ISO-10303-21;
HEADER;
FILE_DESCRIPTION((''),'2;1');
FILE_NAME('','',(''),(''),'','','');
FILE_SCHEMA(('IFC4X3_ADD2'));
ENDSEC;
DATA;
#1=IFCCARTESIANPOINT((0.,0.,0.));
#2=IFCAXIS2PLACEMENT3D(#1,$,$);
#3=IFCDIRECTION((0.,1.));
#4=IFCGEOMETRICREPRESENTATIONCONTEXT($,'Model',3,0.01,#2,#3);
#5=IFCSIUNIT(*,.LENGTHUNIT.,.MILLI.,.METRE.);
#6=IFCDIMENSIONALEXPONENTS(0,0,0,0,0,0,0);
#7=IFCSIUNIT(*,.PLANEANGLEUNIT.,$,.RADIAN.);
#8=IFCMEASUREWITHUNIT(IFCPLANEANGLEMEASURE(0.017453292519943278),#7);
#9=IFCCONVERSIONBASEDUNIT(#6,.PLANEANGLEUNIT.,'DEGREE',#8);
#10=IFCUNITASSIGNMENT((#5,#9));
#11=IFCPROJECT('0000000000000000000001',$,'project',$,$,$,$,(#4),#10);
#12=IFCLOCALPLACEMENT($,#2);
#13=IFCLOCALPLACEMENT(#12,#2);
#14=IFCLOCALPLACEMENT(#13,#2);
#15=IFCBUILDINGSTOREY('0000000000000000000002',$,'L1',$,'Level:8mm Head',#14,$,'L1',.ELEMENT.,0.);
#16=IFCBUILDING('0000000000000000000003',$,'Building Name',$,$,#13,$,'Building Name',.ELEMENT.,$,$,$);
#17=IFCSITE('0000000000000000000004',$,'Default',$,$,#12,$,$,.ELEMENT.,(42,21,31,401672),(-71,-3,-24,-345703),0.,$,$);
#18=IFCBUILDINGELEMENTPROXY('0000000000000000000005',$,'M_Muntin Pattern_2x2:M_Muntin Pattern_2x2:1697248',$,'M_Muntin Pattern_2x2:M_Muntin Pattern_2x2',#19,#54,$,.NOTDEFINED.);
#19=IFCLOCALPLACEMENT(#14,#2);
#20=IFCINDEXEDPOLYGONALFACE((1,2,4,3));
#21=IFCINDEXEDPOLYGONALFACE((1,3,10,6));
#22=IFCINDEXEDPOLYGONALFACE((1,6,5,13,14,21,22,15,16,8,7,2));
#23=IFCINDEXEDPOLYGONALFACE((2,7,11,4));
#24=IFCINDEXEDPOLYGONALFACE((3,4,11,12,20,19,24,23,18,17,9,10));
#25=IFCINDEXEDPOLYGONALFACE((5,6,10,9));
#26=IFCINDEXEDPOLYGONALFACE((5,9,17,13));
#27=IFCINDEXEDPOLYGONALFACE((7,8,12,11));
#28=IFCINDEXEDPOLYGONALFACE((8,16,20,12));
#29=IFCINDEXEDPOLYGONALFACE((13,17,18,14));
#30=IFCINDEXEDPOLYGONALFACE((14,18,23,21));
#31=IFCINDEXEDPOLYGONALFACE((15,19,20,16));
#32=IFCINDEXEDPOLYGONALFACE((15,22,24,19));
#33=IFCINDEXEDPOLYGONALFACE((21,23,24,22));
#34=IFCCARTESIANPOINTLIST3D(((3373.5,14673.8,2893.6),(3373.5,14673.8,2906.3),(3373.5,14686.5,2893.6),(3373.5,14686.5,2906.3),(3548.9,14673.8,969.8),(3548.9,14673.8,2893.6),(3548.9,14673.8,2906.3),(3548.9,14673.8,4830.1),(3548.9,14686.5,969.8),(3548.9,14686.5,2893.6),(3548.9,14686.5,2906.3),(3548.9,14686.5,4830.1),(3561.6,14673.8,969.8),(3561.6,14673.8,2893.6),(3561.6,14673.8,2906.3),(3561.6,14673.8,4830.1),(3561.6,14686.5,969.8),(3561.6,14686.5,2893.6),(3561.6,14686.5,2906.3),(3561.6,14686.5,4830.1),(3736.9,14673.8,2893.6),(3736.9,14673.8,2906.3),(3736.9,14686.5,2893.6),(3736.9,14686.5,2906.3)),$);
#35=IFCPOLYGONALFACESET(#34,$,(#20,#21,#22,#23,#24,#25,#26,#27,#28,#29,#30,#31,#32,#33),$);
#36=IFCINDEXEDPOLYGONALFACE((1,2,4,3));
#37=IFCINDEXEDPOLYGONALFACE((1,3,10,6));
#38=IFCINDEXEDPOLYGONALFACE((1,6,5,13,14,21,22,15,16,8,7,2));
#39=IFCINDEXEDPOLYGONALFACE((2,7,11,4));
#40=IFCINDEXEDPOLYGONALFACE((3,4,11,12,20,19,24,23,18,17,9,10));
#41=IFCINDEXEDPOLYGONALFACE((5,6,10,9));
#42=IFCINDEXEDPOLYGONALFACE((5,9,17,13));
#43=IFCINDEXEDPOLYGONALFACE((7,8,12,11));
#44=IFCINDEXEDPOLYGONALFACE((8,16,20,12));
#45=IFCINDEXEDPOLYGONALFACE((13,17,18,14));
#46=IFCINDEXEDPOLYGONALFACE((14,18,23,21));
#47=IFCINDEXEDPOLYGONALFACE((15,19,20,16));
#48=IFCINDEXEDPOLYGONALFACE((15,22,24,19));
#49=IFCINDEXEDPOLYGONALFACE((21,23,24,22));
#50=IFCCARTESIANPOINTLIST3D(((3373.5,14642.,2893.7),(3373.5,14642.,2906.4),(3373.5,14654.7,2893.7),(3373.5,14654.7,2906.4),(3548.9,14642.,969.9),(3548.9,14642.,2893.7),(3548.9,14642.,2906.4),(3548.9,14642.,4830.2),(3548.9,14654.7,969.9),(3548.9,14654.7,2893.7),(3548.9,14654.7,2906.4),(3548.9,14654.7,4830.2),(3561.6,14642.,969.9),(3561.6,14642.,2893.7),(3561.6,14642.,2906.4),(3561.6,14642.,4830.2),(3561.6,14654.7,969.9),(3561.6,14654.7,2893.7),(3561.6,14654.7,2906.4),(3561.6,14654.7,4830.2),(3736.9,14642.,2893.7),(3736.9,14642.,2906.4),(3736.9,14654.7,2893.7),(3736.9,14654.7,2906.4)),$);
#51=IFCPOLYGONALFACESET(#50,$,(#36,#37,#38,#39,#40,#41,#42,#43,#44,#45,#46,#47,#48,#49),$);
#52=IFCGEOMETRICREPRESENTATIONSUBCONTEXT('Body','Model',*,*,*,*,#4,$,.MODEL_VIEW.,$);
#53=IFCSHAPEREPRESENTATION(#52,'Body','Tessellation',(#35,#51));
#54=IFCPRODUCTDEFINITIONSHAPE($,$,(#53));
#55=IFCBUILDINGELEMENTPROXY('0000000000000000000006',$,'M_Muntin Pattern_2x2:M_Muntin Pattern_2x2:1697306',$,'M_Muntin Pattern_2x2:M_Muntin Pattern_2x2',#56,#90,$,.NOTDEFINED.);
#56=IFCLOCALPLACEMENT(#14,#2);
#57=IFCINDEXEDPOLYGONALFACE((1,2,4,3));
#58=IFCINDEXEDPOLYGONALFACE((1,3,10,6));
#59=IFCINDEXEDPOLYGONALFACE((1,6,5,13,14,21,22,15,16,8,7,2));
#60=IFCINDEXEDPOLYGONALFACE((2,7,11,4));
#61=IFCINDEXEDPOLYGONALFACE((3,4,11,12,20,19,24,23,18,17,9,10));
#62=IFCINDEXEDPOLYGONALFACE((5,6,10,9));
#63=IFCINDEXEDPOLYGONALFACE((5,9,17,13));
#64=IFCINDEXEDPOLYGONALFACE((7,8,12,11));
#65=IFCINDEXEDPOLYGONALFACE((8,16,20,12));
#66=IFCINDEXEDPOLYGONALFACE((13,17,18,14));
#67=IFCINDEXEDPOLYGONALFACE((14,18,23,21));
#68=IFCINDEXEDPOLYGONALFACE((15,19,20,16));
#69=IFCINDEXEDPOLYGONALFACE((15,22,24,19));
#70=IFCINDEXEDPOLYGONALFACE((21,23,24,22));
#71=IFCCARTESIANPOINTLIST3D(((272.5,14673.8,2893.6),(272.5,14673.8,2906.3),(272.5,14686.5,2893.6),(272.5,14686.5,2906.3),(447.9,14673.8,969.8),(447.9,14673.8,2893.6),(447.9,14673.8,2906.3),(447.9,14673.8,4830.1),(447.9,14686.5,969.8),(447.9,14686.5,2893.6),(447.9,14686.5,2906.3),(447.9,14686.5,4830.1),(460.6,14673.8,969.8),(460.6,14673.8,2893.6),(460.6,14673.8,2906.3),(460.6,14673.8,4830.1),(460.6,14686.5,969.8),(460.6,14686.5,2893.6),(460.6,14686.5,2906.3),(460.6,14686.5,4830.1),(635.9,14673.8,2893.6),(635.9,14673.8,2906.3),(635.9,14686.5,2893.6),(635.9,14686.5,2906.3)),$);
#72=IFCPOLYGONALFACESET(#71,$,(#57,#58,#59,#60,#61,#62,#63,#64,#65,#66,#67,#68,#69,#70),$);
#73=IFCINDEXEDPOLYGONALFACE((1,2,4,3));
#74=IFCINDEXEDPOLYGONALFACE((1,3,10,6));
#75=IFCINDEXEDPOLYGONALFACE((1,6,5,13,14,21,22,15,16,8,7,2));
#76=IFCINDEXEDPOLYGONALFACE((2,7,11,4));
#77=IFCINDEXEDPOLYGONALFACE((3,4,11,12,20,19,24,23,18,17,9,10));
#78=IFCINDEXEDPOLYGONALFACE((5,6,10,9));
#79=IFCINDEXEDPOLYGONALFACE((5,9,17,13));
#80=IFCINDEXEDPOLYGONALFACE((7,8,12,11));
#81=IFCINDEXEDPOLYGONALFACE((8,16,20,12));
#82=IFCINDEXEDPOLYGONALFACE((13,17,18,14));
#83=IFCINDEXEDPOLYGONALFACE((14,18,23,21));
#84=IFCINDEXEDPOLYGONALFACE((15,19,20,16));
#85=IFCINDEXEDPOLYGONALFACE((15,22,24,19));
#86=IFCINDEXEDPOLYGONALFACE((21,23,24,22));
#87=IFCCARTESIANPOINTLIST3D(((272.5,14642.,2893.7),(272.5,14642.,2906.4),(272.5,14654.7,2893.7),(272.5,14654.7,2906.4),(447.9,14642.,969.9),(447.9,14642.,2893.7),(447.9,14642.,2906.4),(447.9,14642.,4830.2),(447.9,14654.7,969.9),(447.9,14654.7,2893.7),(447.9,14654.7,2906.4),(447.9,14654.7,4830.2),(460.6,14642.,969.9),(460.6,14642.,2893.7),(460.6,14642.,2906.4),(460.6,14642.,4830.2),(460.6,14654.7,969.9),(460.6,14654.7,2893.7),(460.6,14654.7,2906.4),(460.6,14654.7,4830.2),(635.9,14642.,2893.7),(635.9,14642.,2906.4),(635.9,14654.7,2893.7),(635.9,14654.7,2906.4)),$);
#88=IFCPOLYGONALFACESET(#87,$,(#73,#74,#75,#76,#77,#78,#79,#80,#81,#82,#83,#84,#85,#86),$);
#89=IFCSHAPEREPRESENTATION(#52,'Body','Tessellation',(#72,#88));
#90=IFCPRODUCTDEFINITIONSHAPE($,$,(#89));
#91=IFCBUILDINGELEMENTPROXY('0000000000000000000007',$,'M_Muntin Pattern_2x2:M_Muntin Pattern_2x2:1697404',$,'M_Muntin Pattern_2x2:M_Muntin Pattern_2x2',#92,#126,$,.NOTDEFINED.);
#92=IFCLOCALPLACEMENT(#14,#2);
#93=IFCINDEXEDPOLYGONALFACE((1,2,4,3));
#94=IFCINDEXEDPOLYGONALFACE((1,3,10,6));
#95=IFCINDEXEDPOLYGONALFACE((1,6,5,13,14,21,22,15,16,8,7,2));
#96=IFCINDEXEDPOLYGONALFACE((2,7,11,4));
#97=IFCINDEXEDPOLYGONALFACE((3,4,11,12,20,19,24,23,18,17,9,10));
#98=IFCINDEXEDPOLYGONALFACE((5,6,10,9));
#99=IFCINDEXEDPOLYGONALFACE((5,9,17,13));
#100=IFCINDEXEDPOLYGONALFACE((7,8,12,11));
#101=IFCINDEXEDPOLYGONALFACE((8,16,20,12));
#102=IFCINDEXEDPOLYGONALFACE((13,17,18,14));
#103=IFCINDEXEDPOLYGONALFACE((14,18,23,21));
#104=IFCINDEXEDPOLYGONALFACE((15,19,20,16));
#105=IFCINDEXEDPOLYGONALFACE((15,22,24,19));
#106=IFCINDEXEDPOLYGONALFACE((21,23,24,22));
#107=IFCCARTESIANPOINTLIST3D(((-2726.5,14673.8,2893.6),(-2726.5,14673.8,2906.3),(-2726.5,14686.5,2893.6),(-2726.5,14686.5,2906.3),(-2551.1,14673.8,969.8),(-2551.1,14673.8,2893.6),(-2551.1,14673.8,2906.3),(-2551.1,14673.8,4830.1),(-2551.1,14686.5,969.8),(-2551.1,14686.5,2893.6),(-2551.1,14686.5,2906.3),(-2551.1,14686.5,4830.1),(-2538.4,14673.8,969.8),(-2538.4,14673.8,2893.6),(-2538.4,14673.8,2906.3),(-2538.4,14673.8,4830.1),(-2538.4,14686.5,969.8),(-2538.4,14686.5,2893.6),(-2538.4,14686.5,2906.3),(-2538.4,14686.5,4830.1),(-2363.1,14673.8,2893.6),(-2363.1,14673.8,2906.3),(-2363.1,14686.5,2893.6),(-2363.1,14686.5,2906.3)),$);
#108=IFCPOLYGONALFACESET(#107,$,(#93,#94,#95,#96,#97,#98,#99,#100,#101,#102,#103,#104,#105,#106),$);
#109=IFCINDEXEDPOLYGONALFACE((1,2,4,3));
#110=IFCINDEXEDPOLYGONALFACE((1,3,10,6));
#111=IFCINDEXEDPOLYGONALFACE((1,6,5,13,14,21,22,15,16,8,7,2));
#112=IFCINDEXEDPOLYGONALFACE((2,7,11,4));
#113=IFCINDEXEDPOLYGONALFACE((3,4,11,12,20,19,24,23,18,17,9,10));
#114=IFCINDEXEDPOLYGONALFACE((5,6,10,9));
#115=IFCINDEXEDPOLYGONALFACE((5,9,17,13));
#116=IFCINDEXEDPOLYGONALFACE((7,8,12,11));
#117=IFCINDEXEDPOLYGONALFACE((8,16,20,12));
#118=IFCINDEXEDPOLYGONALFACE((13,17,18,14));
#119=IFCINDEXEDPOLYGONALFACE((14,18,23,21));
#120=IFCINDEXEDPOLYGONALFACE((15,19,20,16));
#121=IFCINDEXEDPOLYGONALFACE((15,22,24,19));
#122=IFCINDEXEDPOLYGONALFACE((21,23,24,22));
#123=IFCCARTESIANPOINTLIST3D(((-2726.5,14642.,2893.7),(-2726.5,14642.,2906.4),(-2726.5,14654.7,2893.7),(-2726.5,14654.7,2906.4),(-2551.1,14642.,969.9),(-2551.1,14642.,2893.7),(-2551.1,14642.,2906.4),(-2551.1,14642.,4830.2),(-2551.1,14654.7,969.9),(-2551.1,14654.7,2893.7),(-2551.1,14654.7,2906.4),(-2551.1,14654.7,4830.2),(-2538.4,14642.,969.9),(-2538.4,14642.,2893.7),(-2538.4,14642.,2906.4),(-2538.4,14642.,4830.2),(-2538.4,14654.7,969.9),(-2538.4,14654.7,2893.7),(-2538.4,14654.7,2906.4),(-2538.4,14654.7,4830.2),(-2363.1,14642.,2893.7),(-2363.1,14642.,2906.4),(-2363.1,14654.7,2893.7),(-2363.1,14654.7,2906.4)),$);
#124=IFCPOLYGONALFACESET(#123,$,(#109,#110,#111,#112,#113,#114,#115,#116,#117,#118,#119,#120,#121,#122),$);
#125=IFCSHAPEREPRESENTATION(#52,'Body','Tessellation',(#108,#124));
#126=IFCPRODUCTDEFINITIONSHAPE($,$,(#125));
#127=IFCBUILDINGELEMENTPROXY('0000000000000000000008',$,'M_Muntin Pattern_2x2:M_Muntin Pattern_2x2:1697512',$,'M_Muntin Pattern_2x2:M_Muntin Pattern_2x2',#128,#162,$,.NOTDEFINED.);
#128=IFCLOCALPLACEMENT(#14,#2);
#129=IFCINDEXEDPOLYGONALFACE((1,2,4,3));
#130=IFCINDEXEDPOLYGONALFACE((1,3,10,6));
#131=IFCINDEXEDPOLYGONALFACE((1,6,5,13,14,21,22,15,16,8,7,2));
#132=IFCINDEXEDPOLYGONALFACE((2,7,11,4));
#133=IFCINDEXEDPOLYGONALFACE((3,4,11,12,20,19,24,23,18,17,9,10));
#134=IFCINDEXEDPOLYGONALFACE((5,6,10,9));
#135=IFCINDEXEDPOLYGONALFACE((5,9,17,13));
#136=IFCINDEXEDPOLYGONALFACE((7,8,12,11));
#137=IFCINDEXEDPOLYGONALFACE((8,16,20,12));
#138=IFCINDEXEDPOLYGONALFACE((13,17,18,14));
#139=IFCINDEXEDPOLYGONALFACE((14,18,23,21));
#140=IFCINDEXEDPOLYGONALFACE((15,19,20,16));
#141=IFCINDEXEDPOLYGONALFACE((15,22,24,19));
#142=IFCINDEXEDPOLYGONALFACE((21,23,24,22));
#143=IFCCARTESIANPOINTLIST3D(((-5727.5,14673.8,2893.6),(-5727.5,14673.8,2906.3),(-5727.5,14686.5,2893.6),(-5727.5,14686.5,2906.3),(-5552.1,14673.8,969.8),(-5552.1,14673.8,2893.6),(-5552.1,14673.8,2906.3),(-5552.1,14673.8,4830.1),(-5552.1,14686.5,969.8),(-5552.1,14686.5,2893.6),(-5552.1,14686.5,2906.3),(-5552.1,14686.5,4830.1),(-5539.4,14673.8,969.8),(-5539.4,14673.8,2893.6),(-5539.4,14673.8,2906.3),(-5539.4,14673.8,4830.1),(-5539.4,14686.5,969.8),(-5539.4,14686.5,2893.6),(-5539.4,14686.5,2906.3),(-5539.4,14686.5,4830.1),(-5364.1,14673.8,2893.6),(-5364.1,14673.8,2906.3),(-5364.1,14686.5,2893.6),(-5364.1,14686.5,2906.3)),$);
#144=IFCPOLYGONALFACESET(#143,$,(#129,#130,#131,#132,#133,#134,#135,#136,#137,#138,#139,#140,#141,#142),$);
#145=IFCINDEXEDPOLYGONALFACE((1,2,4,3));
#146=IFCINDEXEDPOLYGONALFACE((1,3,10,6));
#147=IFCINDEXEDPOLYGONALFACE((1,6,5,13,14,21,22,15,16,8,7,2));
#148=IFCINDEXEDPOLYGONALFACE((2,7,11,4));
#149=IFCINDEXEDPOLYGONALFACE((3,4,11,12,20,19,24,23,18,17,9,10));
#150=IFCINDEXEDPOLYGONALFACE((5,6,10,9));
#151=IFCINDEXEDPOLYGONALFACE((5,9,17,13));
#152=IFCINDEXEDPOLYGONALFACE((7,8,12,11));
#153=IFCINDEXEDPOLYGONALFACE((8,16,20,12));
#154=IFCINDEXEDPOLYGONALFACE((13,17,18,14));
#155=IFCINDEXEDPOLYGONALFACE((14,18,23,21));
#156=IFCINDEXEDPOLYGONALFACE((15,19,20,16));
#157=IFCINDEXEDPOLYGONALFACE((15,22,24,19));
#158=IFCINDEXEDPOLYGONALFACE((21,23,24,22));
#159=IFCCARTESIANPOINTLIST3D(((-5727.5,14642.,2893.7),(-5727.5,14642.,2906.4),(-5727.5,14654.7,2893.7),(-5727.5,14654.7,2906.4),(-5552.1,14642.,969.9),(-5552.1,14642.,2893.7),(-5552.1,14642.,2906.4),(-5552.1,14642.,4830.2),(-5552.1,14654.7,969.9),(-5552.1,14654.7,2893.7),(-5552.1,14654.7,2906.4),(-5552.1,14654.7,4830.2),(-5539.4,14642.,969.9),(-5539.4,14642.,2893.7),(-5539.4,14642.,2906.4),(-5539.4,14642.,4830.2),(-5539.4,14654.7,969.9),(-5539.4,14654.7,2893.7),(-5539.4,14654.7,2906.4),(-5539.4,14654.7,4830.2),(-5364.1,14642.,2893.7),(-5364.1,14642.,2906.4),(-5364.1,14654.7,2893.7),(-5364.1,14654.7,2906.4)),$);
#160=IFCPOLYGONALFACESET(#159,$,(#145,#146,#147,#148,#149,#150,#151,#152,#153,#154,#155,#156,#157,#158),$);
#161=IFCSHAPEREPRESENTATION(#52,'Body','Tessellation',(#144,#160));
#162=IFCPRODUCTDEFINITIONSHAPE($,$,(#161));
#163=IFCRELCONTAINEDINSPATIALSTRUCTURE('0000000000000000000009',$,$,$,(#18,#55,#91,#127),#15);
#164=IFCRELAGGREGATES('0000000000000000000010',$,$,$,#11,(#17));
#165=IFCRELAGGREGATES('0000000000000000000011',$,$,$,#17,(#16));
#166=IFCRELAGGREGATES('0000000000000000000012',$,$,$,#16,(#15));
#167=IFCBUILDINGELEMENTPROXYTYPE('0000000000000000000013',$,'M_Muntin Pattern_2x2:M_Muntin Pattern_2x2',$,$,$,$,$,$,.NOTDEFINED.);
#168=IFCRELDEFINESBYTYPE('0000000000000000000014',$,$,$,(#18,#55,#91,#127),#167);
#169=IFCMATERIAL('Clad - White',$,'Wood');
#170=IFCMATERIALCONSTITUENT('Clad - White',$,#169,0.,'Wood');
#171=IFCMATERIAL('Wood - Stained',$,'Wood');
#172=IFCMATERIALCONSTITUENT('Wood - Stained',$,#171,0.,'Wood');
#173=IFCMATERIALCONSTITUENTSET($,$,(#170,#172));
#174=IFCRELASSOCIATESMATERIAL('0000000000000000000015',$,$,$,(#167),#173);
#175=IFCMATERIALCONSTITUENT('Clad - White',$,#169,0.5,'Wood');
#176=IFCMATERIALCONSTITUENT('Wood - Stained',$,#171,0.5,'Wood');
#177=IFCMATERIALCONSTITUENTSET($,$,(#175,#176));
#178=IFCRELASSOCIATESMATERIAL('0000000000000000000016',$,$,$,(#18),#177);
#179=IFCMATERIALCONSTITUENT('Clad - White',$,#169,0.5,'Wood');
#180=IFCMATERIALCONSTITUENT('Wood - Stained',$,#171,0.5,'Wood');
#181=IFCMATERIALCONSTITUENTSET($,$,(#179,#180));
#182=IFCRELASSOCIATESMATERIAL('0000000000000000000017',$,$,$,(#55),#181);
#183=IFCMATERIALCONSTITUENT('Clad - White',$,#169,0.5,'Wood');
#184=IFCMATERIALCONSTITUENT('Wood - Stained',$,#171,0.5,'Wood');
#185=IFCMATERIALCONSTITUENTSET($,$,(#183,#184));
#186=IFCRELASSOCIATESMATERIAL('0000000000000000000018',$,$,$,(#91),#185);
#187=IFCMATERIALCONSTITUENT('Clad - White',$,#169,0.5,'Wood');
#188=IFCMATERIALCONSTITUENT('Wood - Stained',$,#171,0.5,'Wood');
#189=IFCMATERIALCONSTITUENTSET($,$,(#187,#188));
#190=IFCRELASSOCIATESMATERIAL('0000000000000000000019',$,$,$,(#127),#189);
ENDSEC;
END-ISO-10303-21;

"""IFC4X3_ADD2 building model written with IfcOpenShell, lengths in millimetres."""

from ifc_helpers import new_model, entity, si_unit, converted_unit, direction, frame, origin, place, context, subcontext, project, spatial, polyline, outline, extrude, source, transform, mapped, material, constituent, constituent_set, type_object, type_shapes, element, save


model = new_model("IFC4X3_ADD2")

# Units and contexts
model_context = context("Model", 3, precision=0.01, world=origin(), true_north=direction((0.0, 1.0)))
body_context = subcontext(model_context, "Body", "Model", "MODEL_VIEW")
ifc_project = project(units=[si_unit("LENGTHUNIT", "METRE", prefix="MILLI"), converted_unit("PLANEANGLEUNIT", "DEGREE", entity("IfcPlaneAngleMeasure", 0.017453292519943278), si_unit("PLANEANGLEUNIT", "RADIAN"), dimensions=[0, 0, 0, 0, 0, 0, 0])], contexts=[model_context])

# Site, building, storey
site_placement = place(None, origin())
site = spatial("IfcSite", under=ifc_project, at=site_placement, Name="Default", CompositionType="ELEMENT", RefLatitude=(42, 21, 31, 401672), RefLongitude=(-71, -3, -24, -345703), RefElevation=0.0)
building_placement = place(site_placement, origin())
building = spatial("IfcBuilding", under=site, at=building_placement, Name="Building Name", LongName="Building Name", CompositionType="ELEMENT")
storey_placement = place(building_placement, origin())
storey = spatial("IfcBuildingStorey", under=building, at=storey_placement, Name="L1", ObjectType="Level:8mm Head", LongName="L1", CompositionType="ELEMENT", Elevation=0.0)

# Building element proxies
ifc_material_1 = material(Name="Clad - White", Category="Wood")
ifc_material_2 = material(Name="Wood - Stained", Category="Wood")
ifc_constituent_1 = constituent(ifc_material_1, Name="Clad - White", Category="Wood", fraction=0.0)
ifc_constituent_2 = constituent(ifc_material_2, Name="Wood - Stained", Category="Wood", fraction=0.0)
ifc_constituent_set_1 = constituent_set(constituents=[ifc_constituent_1, ifc_constituent_2])
building_element_proxy_type_1 = type_object("IfcBuildingElementProxyType", Name="M_Muntin Pattern_2x2:M_Muntin Pattern_2x2", PredefinedType="NOTDEFINED", material=ifc_constituent_set_1)
shared_shape_1 = source(origin(), body_context, "Body", "SweptSolid", [
    extrude(outline(polyline([(6.4, -6.4), (1930.1, -6.4), (1930.1, 6.3), (6.4, 6.3), (6.4, 181.7), (-6.3, 181.7), (-6.3, 6.3), (-1930.2, 6.3), (-1930.2, -6.4), (-6.3, -6.4), (-6.3, -181.7), (6.4, -181.7), (6.4, -6.4)])), frame((0.0, -22.2, 1930.1), z_axis=(0.0, 1.0, 0.0), x_axis=(0.0, 0.0, 1.0)), (0.0, 0.0, 1.0), 12.7),
    extrude(outline(polyline([(6.4, -6.4), (1930.2, -6.4), (1930.2, 6.3), (6.4, 6.3), (6.4, 181.7), (-6.3, 181.7), (-6.3, 6.3), (-1930.2, 6.3), (-1930.2, -6.4), (-6.3, -6.4), (-6.3, -181.7), (6.4, -181.7), (6.4, -6.4)])), frame((0.0, 9.5, 1930.2), z_axis=(0.0, 1.0, 0.0), x_axis=(0.0, 0.0, 1.0)), (0.0, 0.0, 1.0), 12.7),
])
type_shapes(building_element_proxy_type_1, [shared_shape_1])
ifc_constituent_3 = constituent(ifc_material_1, Name="Clad - White", Category="Wood", fraction=0.5)
ifc_constituent_4 = constituent(ifc_material_2, Name="Wood - Stained", Category="Wood", fraction=0.5)
ifc_constituent_set_2 = constituent_set(constituents=[ifc_constituent_3, ifc_constituent_4])
proxy_1_placement = place(storey_placement, frame((3555.2, 14664.3, 969.9), z_axis=(0.0, 0.0, 1.0), x_axis=(-1.0, 0.0, 0.0)))
element("IfcBuildingElementProxy", 1, at=proxy_1_placement, inside=storey, type_object=building_element_proxy_type_1, material=ifc_constituent_set_2, Name="M_Muntin Pattern_2x2:M_Muntin Pattern_2x2:1697248", ObjectType="M_Muntin Pattern_2x2:M_Muntin Pattern_2x2", PredefinedType="NOTDEFINED", context=body_context, shape_type="MappedRepresentation", body=[
    mapped(shared_shape_1, transform((0.0, 0.0, 0.0), scale=1.0)),
])
ifc_constituent_5 = constituent(ifc_material_1, Name="Clad - White", Category="Wood", fraction=0.5)
ifc_constituent_6 = constituent(ifc_material_2, Name="Wood - Stained", Category="Wood", fraction=0.5)
ifc_constituent_set_3 = constituent_set(constituents=[ifc_constituent_5, ifc_constituent_6])
proxy_2_placement = place(storey_placement, frame((454.2, 14664.3, 969.9), z_axis=(0.0, 0.0, 1.0), x_axis=(-1.0, 0.0, 0.0)))
element("IfcBuildingElementProxy", 2, at=proxy_2_placement, inside=storey, type_object=building_element_proxy_type_1, material=ifc_constituent_set_3, Name="M_Muntin Pattern_2x2:M_Muntin Pattern_2x2:1697306", ObjectType="M_Muntin Pattern_2x2:M_Muntin Pattern_2x2", PredefinedType="NOTDEFINED", context=body_context, shape_type="MappedRepresentation", body=[
    mapped(shared_shape_1, transform((0.0, 0.0, 0.0), scale=1.0)),
])
ifc_constituent_7 = constituent(ifc_material_1, Name="Clad - White", Category="Wood", fraction=0.5)
ifc_constituent_8 = constituent(ifc_material_2, Name="Wood - Stained", Category="Wood", fraction=0.5)
ifc_constituent_set_4 = constituent_set(constituents=[ifc_constituent_7, ifc_constituent_8])
proxy_3_placement = place(storey_placement, frame((-2544.8, 14664.3, 969.9), z_axis=(0.0, 0.0, 1.0), x_axis=(-1.0, 0.0, 0.0)))
element("IfcBuildingElementProxy", 3, at=proxy_3_placement, inside=storey, type_object=building_element_proxy_type_1, material=ifc_constituent_set_4, Name="M_Muntin Pattern_2x2:M_Muntin Pattern_2x2:1697404", ObjectType="M_Muntin Pattern_2x2:M_Muntin Pattern_2x2", PredefinedType="NOTDEFINED", context=body_context, shape_type="MappedRepresentation", body=[
    mapped(shared_shape_1, transform((0.0, 0.0, 0.0), scale=1.0)),
])
ifc_constituent_9 = constituent(ifc_material_1, Name="Clad - White", Category="Wood", fraction=0.5)
ifc_constituent_10 = constituent(ifc_material_2, Name="Wood - Stained", Category="Wood", fraction=0.5)
ifc_constituent_set_5 = constituent_set(constituents=[ifc_constituent_9, ifc_constituent_10])
proxy_4_placement = place(storey_placement, frame((-5545.8, 14664.3, 969.9), z_axis=(0.0, 0.0, 1.0), x_axis=(-1.0, 0.0, 0.0)))
element("IfcBuildingElementProxy", 4, at=proxy_4_placement, inside=storey, type_object=building_element_proxy_type_1, material=ifc_constituent_set_5, Name="M_Muntin Pattern_2x2:M_Muntin Pattern_2x2:1697512", ObjectType="M_Muntin Pattern_2x2:M_Muntin Pattern_2x2", PredefinedType="NOTDEFINED", context=body_context, shape_type="MappedRepresentation", body=[
    mapped(shared_shape_1, transform((0.0, 0.0, 0.0), scale=1.0)),
])

save(model, "model.ifc")
